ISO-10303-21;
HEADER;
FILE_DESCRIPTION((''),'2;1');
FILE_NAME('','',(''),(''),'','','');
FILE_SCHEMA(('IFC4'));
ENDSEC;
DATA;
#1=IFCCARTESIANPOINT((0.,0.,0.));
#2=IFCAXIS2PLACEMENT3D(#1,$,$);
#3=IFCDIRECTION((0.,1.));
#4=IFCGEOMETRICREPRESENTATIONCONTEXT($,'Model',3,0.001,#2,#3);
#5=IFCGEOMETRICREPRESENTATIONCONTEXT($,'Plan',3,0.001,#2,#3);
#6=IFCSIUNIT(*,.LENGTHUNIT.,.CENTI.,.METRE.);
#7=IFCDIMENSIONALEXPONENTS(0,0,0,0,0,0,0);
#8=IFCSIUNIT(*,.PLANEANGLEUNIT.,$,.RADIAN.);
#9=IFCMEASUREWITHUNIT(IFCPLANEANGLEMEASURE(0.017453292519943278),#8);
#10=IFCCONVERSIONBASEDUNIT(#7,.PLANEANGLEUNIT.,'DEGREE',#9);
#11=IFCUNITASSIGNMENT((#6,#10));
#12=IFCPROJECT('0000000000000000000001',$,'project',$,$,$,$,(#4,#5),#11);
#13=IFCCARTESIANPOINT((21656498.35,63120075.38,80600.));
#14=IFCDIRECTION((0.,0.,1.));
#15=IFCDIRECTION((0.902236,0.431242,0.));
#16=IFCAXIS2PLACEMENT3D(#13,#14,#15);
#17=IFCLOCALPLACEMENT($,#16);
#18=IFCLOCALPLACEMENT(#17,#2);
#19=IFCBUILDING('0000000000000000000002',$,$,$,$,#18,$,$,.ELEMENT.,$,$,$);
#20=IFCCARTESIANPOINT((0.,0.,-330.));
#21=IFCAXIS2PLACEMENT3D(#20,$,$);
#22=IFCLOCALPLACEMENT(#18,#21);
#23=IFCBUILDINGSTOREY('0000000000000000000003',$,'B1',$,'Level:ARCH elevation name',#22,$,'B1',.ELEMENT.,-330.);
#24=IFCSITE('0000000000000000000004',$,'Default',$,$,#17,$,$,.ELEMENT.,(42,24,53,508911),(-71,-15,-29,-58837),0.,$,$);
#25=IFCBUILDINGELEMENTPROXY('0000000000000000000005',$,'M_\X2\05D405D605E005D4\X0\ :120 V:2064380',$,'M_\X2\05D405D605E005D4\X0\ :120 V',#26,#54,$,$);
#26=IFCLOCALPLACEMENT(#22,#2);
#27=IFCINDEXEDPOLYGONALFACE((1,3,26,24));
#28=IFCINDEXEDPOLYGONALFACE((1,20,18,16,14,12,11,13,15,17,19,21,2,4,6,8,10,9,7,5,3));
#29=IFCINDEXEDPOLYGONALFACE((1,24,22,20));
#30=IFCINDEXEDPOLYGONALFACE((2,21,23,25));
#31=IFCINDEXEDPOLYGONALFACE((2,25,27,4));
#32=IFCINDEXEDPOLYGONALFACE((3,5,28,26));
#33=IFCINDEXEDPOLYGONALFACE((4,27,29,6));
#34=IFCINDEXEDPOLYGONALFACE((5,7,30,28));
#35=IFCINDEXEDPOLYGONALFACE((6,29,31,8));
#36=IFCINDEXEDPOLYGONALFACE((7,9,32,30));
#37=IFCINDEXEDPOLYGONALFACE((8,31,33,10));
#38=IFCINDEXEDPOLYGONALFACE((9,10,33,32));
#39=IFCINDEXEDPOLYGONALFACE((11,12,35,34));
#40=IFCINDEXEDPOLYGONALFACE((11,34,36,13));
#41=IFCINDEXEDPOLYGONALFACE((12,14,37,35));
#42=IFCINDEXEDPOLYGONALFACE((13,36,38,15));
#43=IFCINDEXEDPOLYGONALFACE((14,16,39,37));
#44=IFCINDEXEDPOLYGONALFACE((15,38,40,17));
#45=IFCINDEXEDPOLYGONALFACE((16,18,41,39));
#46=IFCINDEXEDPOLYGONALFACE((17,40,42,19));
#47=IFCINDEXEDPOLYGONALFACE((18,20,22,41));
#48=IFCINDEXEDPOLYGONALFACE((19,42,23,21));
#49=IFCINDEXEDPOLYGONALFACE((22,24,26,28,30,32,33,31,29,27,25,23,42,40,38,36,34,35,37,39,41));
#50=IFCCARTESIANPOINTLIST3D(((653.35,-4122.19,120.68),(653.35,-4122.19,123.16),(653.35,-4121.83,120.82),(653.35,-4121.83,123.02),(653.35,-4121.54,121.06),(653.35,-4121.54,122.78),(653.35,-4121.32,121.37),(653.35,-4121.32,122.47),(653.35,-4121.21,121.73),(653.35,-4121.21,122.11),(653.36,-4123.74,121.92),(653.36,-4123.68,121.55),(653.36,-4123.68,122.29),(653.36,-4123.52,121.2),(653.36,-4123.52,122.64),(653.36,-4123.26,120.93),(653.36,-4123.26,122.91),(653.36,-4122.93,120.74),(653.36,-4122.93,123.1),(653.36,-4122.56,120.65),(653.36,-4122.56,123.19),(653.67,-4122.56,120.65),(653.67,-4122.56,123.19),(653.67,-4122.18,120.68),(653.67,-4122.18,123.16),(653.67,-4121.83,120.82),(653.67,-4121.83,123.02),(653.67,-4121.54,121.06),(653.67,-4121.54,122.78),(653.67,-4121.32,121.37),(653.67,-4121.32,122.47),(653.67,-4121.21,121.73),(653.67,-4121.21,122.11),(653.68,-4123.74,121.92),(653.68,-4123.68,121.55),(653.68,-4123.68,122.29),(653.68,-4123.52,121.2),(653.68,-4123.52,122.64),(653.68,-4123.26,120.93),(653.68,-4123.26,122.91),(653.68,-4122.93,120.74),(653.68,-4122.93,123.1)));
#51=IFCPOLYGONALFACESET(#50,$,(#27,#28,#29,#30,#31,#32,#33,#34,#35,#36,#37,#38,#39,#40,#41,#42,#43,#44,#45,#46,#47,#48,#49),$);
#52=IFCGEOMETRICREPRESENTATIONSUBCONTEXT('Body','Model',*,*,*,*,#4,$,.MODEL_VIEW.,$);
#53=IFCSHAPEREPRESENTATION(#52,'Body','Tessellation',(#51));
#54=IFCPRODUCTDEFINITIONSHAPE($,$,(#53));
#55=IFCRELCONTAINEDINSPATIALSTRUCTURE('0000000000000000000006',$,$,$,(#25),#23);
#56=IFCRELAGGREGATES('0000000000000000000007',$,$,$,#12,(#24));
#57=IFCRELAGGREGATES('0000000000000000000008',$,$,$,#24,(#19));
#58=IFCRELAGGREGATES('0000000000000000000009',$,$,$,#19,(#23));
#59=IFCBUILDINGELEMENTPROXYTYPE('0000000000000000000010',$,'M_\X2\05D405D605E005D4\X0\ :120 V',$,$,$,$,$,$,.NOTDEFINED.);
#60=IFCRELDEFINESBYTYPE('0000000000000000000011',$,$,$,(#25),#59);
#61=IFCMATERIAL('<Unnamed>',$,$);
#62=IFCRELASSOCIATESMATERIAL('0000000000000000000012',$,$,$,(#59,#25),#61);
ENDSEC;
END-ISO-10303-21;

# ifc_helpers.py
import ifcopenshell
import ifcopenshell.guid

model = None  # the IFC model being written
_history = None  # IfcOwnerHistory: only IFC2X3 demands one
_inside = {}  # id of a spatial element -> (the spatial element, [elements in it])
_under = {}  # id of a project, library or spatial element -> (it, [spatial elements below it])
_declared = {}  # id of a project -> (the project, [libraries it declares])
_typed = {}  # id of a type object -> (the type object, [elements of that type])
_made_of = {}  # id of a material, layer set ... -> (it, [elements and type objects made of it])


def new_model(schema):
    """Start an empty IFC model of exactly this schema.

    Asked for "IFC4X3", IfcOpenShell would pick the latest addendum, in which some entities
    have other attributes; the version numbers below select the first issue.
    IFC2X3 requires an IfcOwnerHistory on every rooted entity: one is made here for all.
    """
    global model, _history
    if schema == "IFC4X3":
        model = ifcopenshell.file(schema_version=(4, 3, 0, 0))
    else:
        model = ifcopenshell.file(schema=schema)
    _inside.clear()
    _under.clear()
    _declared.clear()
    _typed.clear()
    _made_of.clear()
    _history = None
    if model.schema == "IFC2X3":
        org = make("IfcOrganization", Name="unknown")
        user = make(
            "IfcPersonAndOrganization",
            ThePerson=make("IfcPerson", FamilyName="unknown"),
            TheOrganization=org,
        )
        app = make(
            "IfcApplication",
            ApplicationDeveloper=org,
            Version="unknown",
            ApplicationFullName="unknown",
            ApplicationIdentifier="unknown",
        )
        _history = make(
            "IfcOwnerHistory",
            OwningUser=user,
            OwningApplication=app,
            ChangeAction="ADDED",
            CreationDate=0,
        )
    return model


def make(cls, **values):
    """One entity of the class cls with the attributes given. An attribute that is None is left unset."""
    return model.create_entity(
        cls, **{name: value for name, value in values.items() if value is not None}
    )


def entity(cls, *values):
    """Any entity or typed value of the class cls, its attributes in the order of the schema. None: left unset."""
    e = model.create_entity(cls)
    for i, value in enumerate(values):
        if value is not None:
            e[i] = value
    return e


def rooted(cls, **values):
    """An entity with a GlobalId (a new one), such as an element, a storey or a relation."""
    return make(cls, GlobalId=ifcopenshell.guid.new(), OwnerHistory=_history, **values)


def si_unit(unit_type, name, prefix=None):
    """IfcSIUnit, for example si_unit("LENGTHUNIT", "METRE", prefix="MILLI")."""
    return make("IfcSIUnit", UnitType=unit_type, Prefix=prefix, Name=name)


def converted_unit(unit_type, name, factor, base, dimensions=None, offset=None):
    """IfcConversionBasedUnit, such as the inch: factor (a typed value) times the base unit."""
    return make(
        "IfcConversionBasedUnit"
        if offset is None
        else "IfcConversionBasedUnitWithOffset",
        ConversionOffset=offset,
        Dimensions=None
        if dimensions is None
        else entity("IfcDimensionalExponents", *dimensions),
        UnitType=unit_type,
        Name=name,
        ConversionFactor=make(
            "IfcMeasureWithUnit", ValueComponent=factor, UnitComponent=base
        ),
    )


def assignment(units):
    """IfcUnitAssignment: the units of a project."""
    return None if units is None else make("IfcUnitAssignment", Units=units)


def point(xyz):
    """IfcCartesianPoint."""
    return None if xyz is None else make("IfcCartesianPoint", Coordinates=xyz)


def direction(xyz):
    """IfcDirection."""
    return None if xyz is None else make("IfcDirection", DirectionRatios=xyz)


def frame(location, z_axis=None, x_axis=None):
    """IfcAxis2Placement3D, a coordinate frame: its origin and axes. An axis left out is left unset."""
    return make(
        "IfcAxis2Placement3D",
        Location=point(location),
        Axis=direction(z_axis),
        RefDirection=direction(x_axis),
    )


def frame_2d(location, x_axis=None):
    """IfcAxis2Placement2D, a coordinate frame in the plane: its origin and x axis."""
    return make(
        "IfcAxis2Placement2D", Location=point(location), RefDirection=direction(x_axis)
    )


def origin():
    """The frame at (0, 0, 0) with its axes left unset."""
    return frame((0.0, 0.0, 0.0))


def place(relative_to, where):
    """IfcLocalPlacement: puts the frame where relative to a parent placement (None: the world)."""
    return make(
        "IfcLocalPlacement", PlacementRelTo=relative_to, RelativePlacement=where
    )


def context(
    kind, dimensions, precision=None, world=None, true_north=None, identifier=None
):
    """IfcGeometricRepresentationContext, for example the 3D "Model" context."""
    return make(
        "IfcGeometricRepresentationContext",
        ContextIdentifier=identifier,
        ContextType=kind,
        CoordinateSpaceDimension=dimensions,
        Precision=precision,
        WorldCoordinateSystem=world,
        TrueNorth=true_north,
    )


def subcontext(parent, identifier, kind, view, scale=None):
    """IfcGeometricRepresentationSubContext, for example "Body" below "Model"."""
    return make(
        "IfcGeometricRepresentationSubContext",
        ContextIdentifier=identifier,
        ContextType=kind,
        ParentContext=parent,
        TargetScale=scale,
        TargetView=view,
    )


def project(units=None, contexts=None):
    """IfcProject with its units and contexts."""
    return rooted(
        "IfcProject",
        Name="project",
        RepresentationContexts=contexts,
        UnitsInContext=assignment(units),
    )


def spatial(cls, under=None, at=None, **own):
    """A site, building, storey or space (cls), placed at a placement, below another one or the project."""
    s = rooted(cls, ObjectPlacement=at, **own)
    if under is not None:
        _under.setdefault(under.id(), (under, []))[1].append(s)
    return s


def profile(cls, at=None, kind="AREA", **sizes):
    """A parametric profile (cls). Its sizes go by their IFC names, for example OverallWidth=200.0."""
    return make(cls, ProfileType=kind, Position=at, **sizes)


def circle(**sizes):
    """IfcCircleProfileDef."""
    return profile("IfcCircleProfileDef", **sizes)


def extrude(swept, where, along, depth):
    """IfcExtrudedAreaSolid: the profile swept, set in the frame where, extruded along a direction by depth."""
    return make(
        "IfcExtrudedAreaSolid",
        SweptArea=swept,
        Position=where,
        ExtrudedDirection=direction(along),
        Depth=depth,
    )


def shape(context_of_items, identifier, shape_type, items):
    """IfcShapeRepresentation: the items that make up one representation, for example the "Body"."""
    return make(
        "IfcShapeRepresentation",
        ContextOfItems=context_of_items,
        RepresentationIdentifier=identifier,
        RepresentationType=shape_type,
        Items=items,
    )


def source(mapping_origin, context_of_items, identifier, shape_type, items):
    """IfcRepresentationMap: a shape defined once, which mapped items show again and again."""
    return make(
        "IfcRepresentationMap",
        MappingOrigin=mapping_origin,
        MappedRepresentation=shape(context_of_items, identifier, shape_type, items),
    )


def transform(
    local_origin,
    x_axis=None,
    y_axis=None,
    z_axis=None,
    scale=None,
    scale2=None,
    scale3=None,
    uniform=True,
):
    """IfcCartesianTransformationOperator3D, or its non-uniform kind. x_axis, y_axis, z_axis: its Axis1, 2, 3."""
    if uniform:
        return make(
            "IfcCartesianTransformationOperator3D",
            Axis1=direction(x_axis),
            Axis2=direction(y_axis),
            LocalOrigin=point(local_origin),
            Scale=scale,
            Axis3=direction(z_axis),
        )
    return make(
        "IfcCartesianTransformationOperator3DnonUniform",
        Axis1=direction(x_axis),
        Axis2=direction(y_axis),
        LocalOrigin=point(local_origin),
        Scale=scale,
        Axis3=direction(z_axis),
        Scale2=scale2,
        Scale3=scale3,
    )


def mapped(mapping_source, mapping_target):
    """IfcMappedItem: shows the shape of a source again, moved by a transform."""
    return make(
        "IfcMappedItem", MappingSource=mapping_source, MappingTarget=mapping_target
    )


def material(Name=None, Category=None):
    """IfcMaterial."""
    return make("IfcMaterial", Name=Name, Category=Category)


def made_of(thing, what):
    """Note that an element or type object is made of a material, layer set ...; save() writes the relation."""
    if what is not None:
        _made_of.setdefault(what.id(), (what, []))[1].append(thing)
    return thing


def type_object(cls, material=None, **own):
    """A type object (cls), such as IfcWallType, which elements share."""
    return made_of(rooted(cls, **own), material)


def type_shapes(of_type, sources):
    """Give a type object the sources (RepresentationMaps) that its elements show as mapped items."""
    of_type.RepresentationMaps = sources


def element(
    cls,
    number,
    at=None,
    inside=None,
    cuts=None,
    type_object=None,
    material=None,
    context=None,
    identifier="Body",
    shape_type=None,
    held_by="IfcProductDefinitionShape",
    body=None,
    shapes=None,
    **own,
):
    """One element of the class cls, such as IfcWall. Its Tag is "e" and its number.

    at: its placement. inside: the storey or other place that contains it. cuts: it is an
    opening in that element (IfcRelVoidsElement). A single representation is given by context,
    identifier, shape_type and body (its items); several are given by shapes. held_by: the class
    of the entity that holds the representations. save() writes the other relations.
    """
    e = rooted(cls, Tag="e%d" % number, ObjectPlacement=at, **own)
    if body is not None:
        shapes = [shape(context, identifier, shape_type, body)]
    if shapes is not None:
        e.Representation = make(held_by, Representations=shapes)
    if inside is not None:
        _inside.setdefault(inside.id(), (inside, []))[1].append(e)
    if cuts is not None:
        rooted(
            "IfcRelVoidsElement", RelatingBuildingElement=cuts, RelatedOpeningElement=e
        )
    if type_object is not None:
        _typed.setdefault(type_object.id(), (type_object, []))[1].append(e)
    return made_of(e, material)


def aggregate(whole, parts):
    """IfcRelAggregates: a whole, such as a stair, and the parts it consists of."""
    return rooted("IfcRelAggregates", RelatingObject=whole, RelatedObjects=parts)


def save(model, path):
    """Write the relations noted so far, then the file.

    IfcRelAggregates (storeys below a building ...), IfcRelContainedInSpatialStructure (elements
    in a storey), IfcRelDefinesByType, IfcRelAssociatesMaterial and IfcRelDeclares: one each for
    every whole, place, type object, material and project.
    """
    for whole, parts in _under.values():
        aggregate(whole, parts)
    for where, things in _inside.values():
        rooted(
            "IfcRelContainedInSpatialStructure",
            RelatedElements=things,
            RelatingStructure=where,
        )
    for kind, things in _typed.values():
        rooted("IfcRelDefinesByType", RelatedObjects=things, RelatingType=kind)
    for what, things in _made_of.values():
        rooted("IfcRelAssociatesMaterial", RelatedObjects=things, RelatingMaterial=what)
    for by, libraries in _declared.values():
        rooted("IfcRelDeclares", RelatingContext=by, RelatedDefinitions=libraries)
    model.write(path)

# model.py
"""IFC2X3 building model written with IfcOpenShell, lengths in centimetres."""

from ifc_helpers import new_model, entity, si_unit, converted_unit, direction, frame, frame_2d, origin, place, context, subcontext, project, spatial, circle, extrude, source, transform, mapped, material, type_object, type_shapes, element, save


model = new_model("IFC2X3")

# Units and contexts
model_context = context("Model", 3, precision=0.001, world=origin(), true_north=direction((0.0, 1.0)))
plan_context = context("Plan", 3, precision=0.001, world=origin(), true_north=direction((0.0, 1.0)))
body_context = subcontext(model_context, "Body", "Model", "MODEL_VIEW")
ifc_project = project(units=[si_unit("LENGTHUNIT", "METRE", prefix="CENTI"), converted_unit("PLANEANGLEUNIT", "DEGREE", entity("IfcPlaneAngleMeasure", 0.017453292519943278), si_unit("PLANEANGLEUNIT", "RADIAN"), dimensions=[0, 0, 0, 0, 0, 0, 0])], contexts=[model_context, plan_context])

# Site, building, storey
site_placement = place(None, frame((21656498.35, 63120075.38, 80600.0), z_axis=(0.0, 0.0, 1.0), x_axis=(0.902236, 0.431242, 0.0)))
site = spatial("IfcSite", under=ifc_project, at=site_placement, Name="Default", CompositionType="ELEMENT", RefLatitude=(42, 24, 53, 508911), RefLongitude=(-71, -15, -29, -58837), RefElevation=0.0)
building_placement = place(site_placement, origin())
building = spatial("IfcBuilding", under=site, at=building_placement, CompositionType="ELEMENT")
storey_placement = place(building_placement, frame((0.0, 0.0, -330.0)))
storey = spatial("IfcBuildingStorey", under=building, at=storey_placement, Name="B1", ObjectType="Level:ARCH elevation name", LongName="B1", CompositionType="ELEMENT", Elevation=-330.0)

# Building element proxy
ifc_material_1 = material(Name="<Unnamed>")
building_element_proxy_type_1 = type_object("IfcBuildingElementProxyType", Name="M_הזנה :120 V", PredefinedType="NOTDEFINED", material=ifc_material_1)
shared_shape_1 = source(origin(), body_context, "Body", "SweptSolid", [
    extrude(circle(Radius=1.27, at=frame_2d((0.0, 0.0), x_axis=(1.0, 0.0))), origin(), (0.0, 0.0, 1.0), 0.32),
])
type_shapes(building_element_proxy_type_1, [shared_shape_1])
for number, where, z_axis, x_axis, name in (
    (1, (653.36, -4122.47, 121.92), (0.999984, 0.005676, 0.0), (0.005676, -0.999984, 0.0), "M_הזנה :120 V:2064380"),
):
    element("IfcBuildingElementProxy", number, at=place(storey_placement, frame(where, z_axis=z_axis, x_axis=x_axis)), inside=storey, type_object=building_element_proxy_type_1, material=ifc_material_1, Name=name, ObjectType="M_הזנה :120 V", context=body_context, shape_type="MappedRepresentation", body=[
        mapped(shared_shape_1, transform((0.0, 0.0, 0.0), scale=1.0)),
    ])

save(model, "model.ifc")
